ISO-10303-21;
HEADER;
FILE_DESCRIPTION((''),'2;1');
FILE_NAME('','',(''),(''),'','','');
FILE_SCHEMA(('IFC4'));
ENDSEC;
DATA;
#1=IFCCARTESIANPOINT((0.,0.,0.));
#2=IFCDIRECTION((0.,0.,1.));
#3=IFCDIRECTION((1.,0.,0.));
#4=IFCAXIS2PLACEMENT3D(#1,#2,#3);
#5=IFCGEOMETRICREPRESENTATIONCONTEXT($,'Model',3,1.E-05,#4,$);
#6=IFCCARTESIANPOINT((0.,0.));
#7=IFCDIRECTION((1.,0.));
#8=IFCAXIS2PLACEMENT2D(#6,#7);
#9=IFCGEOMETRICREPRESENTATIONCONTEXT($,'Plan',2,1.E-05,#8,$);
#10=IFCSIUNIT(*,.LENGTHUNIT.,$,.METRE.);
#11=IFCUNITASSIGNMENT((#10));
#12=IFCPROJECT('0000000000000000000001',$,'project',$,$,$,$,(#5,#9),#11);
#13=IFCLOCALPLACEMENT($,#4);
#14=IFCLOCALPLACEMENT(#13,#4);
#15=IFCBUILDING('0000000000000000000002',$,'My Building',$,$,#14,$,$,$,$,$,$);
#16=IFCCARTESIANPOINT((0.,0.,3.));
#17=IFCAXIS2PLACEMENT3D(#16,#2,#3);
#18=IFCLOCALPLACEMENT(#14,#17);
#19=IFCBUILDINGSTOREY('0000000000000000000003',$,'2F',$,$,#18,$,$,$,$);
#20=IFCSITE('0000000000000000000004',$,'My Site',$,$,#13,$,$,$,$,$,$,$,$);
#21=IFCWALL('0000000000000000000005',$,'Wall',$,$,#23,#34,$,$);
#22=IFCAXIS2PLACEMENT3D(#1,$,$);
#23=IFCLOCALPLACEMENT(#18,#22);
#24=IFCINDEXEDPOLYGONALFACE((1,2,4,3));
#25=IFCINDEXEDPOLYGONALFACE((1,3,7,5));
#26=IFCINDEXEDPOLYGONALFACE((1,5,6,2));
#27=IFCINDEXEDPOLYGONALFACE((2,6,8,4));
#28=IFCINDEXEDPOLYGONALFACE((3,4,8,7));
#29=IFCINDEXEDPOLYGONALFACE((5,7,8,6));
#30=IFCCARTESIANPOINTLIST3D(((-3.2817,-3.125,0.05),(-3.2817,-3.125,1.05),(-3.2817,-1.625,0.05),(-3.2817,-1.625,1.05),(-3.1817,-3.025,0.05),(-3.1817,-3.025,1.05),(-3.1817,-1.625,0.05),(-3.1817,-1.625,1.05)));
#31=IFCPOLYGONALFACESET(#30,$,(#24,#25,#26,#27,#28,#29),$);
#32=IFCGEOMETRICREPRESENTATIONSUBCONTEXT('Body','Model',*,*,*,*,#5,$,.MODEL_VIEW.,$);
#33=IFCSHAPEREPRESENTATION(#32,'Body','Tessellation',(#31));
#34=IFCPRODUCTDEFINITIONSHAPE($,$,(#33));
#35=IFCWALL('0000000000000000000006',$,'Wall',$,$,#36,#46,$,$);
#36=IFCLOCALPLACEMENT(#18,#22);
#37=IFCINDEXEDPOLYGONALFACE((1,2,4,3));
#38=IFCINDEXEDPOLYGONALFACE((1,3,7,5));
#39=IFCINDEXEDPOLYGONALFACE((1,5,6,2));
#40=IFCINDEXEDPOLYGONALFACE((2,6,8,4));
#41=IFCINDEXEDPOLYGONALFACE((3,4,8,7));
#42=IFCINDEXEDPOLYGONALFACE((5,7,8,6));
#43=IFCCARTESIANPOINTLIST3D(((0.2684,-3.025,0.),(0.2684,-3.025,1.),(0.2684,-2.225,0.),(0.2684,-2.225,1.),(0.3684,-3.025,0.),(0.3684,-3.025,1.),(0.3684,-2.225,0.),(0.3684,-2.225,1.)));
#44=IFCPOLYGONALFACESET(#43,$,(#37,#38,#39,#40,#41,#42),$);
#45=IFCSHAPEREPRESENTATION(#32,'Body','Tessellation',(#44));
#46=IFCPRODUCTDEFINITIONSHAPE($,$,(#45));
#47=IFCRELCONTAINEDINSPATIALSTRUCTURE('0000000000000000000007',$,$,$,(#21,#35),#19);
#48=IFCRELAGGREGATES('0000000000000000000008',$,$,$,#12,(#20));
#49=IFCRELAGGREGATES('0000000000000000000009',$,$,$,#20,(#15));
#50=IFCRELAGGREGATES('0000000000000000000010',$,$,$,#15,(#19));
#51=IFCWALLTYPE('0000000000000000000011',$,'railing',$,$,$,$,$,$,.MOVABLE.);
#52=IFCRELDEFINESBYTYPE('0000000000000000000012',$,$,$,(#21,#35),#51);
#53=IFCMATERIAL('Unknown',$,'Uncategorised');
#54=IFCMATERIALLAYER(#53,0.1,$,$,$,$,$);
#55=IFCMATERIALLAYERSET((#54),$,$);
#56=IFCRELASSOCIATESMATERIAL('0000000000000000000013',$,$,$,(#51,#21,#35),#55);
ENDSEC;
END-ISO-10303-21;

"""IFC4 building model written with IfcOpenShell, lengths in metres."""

from ifc_helpers import new_model, si_unit, frame, origin_with_axes, origin_2d_with_axis, place, context, subcontext, project, spatial, line, indexed_curve, outline, extrude, material, layer, layer_set, layer_usage, type_object, element, save


model = new_model("IFC4")

# Units and contexts
model_context = context("Model", 3, precision=1e-05, world=origin_with_axes())
plan_context = context("Plan", 2, precision=1e-05, world=origin_2d_with_axis())
body_context_1 = subcontext(model_context, "Body", "Model", "MODEL_VIEW")
ifc_project = project(units=[si_unit("LENGTHUNIT", "METRE")], contexts=[model_context, plan_context])

# Site, building, storey
site_placement = place(None, origin_with_axes())
site = spatial("IfcSite", under=ifc_project, at=site_placement, Name="My Site")
building_placement = place(site_placement, origin_with_axes())
building = spatial("IfcBuilding", under=site, at=building_placement, Name="My Building")
storey_placement = place(building_placement, frame((0.0, 0.0, 3.0), z_axis=(0.0, 0.0, 1.0), x_axis=(1.0, 0.0, 0.0)))
storey = spatial("IfcBuildingStorey", under=building, at=storey_placement, Name="2F")

# Shared definitions
ifc_material = material(Name="Unknown", Category="Uncategorised")

# Walls
ifc_layer_1 = layer(ifc_material, 0.1)
ifc_layer_set_1 = layer_set([ifc_layer_1])
wall_type_1 = type_object("IfcWallType", Name="railing", PredefinedType="MOVABLE", material=ifc_layer_set_1)
ifc_layer_usage_1 = layer_usage(ifc_layer_set_1, "AXIS2", "POSITIVE", 0.0)
wall_1_placement = place(storey_placement, frame((-3.2817, -1.625, 0.05), z_axis=(0.0, 0.0, 1.0), x_axis=(0.0, -1.0, 0.0)))
element("IfcWall", 1, at=wall_1_placement, inside=storey, type_object=wall_type_1, material=ifc_layer_usage_1, Name="Wall", context=body_context_1, shape_type="SweptSolid", body=[
    extrude(outline(indexed_curve([(0.0, 0.0), (0.0, 0.1), (1.4, 0.1), (1.5, 0.0)], segments=[line(1, 2, 3, 4, 1)])), origin_with_axes(), (0.0, 0.0, 1.0), 1.0),
])
ifc_layer_usage_2 = layer_usage(ifc_layer_set_1, "AXIS2", "POSITIVE", 0.0)
wall_2_placement = place(storey_placement, frame((0.2684, -2.225, 0.0), z_axis=(0.0, 0.0, 1.0), x_axis=(0.0, -1.0, 0.0)))
element("IfcWall", 2, at=wall_2_placement, inside=storey, type_object=wall_type_1, material=ifc_layer_usage_2, Name="Wall", context=body_context_1, shape_type="SweptSolid", body=[
    extrude(outline(indexed_curve([(0.0, 0.0), (0.0, 0.1), (0.8, 0.1), (0.8, 0.0)], segments=[line(1, 2, 3, 4, 1)])), origin_with_axes(), (0.0, 0.0, 1.0), 1.0),
])

save(model, "model.ifc")
